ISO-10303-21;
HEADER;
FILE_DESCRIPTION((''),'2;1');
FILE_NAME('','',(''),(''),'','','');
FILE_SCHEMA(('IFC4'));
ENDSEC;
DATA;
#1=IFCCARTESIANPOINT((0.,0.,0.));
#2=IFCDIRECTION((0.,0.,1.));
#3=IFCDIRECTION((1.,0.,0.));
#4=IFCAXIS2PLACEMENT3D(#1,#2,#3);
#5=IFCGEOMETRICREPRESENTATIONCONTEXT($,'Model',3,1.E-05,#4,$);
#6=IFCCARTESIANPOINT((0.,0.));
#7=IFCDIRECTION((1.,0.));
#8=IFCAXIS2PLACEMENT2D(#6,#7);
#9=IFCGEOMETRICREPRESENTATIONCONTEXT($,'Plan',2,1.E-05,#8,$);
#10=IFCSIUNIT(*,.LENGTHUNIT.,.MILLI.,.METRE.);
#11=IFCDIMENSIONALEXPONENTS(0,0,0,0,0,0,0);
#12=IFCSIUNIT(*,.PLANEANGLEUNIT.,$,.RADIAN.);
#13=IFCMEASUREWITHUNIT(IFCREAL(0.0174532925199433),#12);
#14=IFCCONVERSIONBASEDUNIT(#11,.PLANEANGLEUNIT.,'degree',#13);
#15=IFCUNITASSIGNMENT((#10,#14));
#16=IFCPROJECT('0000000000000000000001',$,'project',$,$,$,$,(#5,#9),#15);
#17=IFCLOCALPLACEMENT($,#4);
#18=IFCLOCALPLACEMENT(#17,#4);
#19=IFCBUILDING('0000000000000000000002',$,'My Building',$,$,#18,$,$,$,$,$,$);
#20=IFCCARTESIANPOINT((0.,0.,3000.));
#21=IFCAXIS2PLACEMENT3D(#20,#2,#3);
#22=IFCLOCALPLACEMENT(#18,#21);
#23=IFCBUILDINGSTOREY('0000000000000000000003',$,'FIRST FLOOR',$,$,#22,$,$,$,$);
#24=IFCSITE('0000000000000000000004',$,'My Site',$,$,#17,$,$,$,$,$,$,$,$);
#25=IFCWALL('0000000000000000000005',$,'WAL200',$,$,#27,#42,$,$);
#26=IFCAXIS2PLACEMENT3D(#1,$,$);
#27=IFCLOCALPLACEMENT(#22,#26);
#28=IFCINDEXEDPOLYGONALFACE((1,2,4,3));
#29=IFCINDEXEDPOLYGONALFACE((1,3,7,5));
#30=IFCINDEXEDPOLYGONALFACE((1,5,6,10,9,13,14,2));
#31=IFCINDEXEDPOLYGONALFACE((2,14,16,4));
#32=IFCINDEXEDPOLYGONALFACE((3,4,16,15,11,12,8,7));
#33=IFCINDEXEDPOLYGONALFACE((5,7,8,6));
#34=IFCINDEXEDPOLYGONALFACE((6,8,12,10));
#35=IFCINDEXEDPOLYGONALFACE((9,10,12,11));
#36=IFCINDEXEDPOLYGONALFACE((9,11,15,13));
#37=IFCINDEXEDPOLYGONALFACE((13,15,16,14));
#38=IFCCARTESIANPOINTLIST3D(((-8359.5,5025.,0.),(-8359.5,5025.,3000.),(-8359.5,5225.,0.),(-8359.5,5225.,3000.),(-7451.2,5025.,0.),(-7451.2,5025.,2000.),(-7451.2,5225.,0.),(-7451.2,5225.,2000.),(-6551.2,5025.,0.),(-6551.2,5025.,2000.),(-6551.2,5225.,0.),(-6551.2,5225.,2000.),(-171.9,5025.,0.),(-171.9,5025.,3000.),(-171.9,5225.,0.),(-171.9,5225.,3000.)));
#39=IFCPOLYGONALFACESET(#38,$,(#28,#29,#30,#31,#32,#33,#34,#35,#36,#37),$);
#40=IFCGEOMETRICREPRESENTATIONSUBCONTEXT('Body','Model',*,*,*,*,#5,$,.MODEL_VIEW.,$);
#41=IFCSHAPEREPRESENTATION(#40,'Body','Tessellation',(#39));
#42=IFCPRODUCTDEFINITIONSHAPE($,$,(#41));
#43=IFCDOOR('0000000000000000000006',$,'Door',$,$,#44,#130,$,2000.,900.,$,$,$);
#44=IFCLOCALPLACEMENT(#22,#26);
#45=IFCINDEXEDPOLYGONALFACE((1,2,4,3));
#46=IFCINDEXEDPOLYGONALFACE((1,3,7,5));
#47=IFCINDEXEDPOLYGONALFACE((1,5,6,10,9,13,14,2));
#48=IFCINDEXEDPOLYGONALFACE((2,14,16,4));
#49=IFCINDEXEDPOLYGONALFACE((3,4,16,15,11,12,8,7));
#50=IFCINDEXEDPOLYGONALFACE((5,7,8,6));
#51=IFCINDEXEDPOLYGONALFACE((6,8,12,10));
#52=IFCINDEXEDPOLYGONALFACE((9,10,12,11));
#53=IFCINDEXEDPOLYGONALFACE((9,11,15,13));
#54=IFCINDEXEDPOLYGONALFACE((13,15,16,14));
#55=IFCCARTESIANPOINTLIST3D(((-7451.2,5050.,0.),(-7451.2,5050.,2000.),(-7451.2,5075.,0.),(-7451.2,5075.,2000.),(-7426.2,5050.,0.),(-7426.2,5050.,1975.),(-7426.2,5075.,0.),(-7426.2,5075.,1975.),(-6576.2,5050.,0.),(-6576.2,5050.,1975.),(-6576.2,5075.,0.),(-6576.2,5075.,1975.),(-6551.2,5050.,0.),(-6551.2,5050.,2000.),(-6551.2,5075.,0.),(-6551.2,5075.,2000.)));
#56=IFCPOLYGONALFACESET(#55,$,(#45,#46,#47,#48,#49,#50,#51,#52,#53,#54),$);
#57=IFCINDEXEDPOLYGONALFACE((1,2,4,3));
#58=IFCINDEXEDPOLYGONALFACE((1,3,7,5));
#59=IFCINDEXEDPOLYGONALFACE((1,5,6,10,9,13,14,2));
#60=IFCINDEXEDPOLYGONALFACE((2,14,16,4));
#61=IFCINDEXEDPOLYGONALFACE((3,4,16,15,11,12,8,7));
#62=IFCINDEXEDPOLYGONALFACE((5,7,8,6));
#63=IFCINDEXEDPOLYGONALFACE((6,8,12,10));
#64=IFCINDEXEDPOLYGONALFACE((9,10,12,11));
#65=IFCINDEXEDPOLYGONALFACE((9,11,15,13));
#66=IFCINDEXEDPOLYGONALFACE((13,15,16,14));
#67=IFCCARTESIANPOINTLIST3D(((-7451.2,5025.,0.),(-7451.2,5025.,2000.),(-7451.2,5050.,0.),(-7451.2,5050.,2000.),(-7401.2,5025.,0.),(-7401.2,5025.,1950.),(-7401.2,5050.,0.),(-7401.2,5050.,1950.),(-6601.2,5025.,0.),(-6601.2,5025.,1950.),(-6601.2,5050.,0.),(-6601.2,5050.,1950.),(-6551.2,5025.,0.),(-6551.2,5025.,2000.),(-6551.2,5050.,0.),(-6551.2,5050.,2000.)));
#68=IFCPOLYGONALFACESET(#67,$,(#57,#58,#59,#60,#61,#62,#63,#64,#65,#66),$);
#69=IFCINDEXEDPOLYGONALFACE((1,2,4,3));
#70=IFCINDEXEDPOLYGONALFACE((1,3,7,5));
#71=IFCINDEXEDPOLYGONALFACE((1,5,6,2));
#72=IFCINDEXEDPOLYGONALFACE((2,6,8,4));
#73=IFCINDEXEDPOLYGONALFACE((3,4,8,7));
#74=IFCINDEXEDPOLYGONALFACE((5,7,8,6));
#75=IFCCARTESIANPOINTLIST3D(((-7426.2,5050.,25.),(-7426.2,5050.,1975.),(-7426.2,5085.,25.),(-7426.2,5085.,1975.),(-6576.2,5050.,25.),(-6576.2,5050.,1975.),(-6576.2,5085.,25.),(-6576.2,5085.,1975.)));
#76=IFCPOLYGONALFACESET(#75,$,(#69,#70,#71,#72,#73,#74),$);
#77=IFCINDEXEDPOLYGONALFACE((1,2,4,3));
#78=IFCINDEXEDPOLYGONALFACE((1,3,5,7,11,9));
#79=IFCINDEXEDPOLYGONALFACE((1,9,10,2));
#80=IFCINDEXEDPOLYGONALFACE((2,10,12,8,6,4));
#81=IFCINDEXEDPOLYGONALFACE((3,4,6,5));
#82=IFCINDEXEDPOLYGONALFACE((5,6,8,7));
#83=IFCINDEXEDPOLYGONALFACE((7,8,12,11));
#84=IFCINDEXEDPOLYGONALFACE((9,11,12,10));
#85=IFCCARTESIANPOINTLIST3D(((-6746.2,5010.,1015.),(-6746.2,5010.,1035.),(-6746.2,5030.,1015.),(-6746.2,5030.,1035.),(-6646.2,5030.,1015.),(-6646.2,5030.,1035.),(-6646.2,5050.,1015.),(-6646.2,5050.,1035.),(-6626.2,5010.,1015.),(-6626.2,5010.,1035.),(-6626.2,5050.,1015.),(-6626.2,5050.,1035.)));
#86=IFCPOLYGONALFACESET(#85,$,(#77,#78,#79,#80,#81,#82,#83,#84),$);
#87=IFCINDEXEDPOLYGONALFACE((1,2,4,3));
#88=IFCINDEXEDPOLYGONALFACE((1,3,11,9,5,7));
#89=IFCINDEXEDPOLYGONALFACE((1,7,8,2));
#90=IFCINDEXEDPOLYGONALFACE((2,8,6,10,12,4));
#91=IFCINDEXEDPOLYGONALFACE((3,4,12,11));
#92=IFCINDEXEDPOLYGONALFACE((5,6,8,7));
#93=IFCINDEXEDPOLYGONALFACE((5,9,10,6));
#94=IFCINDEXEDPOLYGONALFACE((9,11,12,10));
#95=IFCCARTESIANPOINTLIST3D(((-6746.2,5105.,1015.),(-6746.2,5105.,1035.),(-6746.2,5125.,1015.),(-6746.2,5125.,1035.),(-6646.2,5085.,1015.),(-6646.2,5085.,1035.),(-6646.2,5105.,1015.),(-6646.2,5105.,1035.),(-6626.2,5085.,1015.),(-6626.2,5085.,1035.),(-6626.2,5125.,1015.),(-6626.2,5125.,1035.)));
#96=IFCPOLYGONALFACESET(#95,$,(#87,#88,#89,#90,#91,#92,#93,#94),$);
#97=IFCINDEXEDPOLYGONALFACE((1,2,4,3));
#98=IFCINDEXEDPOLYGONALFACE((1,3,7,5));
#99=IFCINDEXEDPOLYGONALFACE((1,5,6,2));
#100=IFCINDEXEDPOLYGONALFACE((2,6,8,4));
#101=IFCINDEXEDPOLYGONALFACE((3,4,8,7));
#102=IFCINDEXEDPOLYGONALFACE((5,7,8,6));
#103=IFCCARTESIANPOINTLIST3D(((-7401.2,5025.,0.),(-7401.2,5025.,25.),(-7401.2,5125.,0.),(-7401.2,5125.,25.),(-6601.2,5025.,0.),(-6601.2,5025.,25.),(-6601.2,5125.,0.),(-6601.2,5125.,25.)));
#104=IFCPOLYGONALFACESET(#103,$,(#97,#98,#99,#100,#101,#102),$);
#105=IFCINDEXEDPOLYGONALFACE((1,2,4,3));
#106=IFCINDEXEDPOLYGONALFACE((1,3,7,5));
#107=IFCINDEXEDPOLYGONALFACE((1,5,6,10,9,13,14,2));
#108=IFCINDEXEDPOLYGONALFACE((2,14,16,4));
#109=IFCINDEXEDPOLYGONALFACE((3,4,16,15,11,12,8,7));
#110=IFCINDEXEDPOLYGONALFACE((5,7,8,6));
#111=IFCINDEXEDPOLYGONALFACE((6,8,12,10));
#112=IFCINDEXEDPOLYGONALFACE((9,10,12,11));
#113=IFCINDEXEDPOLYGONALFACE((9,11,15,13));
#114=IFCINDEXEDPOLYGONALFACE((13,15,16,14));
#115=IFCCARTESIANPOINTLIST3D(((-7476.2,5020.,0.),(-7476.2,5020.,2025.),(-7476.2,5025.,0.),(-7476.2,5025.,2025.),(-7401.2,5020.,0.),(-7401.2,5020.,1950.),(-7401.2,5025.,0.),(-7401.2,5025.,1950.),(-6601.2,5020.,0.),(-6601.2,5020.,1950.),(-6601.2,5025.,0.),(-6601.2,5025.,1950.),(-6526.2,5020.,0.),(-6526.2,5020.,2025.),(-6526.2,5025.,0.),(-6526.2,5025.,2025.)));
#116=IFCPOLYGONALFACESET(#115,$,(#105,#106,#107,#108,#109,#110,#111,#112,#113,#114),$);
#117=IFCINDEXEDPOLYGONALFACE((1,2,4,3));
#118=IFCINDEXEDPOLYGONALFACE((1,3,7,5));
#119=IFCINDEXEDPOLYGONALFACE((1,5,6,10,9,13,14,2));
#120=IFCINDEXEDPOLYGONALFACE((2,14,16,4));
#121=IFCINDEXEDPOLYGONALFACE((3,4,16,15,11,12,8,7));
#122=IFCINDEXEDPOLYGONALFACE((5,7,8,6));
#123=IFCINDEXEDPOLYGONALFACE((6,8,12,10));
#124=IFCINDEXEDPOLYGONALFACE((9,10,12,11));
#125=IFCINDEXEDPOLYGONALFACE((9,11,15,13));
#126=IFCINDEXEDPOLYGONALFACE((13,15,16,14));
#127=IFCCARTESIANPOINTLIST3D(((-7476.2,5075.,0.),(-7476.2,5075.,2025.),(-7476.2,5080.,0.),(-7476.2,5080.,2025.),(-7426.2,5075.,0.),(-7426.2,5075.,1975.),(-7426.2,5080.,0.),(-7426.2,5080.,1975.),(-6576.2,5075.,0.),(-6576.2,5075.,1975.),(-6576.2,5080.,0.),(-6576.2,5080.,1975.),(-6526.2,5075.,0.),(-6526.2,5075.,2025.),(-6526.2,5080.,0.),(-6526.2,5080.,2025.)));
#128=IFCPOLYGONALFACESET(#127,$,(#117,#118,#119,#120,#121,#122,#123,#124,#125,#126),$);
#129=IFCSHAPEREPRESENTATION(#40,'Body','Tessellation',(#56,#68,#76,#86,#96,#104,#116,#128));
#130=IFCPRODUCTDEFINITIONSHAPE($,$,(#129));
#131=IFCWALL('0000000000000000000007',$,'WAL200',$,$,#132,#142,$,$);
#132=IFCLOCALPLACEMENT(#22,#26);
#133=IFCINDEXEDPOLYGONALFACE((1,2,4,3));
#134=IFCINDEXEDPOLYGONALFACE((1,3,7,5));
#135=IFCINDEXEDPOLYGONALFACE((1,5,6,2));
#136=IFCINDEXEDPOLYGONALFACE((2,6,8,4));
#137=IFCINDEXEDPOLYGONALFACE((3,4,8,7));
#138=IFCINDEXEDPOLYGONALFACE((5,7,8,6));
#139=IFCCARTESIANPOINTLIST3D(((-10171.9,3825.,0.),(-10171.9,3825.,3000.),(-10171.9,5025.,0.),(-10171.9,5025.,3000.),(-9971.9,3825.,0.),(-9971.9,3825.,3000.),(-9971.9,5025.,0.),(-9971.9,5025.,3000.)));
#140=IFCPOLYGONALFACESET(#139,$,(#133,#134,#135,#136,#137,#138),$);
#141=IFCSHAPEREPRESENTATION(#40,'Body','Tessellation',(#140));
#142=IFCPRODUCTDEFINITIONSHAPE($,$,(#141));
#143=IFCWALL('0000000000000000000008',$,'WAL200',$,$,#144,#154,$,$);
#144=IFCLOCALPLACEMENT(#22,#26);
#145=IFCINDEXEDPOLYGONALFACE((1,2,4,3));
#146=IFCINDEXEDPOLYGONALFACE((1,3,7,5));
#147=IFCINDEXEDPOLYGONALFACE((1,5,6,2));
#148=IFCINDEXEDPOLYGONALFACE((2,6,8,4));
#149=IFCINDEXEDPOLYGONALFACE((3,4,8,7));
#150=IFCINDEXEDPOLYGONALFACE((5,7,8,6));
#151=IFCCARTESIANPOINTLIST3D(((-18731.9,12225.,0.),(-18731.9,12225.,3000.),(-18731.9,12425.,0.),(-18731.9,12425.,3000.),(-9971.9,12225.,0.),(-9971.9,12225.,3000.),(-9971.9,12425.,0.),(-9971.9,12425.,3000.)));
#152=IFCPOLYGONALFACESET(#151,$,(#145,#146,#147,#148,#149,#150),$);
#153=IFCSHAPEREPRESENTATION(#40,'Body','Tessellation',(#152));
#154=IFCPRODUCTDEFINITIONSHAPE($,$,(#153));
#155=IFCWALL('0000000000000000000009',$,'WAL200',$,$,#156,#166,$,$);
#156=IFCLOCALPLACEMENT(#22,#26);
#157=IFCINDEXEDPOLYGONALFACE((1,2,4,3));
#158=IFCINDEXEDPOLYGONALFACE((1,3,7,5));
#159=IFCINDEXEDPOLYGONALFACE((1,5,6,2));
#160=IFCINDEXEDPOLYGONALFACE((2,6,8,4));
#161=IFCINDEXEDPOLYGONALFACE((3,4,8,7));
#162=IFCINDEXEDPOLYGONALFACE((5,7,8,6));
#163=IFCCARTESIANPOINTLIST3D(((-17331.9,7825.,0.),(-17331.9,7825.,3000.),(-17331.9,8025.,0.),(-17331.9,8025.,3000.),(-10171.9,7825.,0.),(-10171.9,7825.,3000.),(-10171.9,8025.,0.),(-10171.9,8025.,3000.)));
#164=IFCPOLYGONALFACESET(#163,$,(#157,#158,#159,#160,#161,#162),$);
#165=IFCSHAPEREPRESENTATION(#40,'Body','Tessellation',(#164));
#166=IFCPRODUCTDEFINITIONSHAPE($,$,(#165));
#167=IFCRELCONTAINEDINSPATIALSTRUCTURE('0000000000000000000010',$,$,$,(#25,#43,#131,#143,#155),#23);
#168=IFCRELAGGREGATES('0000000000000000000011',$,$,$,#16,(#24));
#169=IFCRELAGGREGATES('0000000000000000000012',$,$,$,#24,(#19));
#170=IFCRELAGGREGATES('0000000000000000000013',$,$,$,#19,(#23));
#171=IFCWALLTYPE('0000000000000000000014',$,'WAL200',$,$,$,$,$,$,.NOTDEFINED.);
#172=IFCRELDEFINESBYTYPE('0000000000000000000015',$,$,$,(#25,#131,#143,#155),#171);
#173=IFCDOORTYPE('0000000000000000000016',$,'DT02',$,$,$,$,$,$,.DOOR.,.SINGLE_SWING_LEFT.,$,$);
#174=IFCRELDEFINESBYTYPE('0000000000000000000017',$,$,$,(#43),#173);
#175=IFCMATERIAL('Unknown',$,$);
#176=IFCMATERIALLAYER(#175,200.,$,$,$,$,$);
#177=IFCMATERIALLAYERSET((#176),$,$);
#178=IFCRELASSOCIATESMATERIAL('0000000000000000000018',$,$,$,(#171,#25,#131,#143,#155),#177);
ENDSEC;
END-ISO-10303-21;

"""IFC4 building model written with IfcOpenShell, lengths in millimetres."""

from ifc_helpers import new_model, entity, si_unit, converted_unit, frame, origin_with_axes, origin_2d_with_axis, place, context, subcontext, project, spatial, line, indexed_curve, outline, extrude, shape, source, transform, mapped, material, layer, layer_set, layer_usage, type_object, type_shapes, element, fill, save


model = new_model("IFC4")

# Units and contexts
model_context = context("Model", 3, precision=1e-05, world=origin_with_axes())
plan_context = context("Plan", 2, precision=1e-05, world=origin_2d_with_axis())
body_context_1 = subcontext(model_context, "Body", "Model", "MODEL_VIEW")
body_context_2 = subcontext(plan_context, "Body", "Plan", "PLAN_VIEW")
ifc_project = project(units=[si_unit("LENGTHUNIT", "METRE", prefix="MILLI"), converted_unit("PLANEANGLEUNIT", "degree", entity("IfcReal", 0.0174532925199433), si_unit("PLANEANGLEUNIT", "RADIAN"), dimensions=[0, 0, 0, 0, 0, 0, 0])], contexts=[model_context, plan_context])

# Site, building, storey
site_placement = place(None, origin_with_axes())
site = spatial("IfcSite", under=ifc_project, at=site_placement, Name="My Site")
building_placement = place(site_placement, origin_with_axes())
building = spatial("IfcBuilding", under=site, at=building_placement, Name="My Building")
storey_placement = place(building_placement, frame((0.0, 0.0, 3000.0), z_axis=(0.0, 0.0, 1.0), x_axis=(1.0, 0.0, 0.0)))
storey = spatial("IfcBuildingStorey", under=building, at=storey_placement, Name="FIRST FLOOR")

# Shared definitions
ifc_material = material(Name="Unknown")

# Shared definitions
ifc_layer_1 = layer(ifc_material, 200.0)
ifc_layer_set_1 = layer_set([ifc_layer_1])
wall_type_1 = type_object("IfcWallType", Name="WAL200", PredefinedType="NOTDEFINED", material=ifc_layer_set_1)

# Wall, opening, door
shared_shape_1 = source(origin_with_axes(), body_context_1, "Body", "SweptSolid", [
    extrude(outline(indexed_curve([(0.0, 0.0), (900.0, 0.0), (900.0, 2000.0), (0.0, 2000.0)], segments=[line(1, 2), line(2, 3), line(3, 4), line(4, 1)])), frame((0.0, -100.0, 0.0), z_axis=(0.0, -1.0, 0.0), x_axis=(1.0, 0.0, 0.0)), (0.0, 0.0, -1.0), 300.0),
])
door_type = type_object("IfcDoorType", Name="DT02", OperationType="SINGLE_SWING_LEFT", PredefinedType="DOOR")
shared_shape_2 = source(origin_with_axes(), body_context_1, "Body", "SweptSolid", [
    extrude(outline(indexed_curve([(0.0, 0.0), (0.0, 2000.0), (900.0, 2000.0), (900.0, 0.0), (875.0, 0.0), (875.0, 1975.0), (25.0, 1975.0), (25.0, 0.0)], segments=[line(1, 2), line(2, 3), line(3, 4), line(4, 5), line(5, 6), line(6, 7), line(7, 8), line(8, 1)])), frame((0.0, 25.0, 0.0), z_axis=(0.0, -1.0, 0.0), x_axis=(1.0, 0.0, 0.0)), (0.0, 0.0, -1.0), 25.0),
    extrude(outline(indexed_curve([(0.0, 0.0), (0.0, 2000.0), (900.0, 2000.0), (900.0, 0.0), (850.0, 0.0), (850.0, 1950.0), (50.0, 1950.0), (50.0, 0.0)], segments=[line(1, 2), line(2, 3), line(3, 4), line(4, 5), line(5, 6), line(6, 7), line(7, 8), line(8, 1)])), frame((0.0, 0.0, 0.0), z_axis=(0.0, -1.0, 0.0), x_axis=(1.0, 0.0, 0.0)), (0.0, 0.0, -1.0), 25.0),
    extrude(outline(indexed_curve([(0.0, 0.0), (850.0, 0.0), (850.0, 35.0), (0.0, 35.0)], segments=[line(1, 2), line(2, 3), line(3, 4), line(4, 1)])), frame((25.0, 25.0, 25.0), z_axis=(0.0, 0.0, 1.0), x_axis=(1.0, 0.0, 0.0)), (0.0, 0.0, 1.0), 1950.0),
    extrude(outline(indexed_curve([(0.0, 0.0), (0.0, -40.0), (-120.0, -40.0), (-120.0, -20.0), (-20.0, -20.0), (-20.0, 0.0)], segments=[line(1, 2), line(2, 3), line(3, 4), line(4, 5), line(5, 6), line(6, 1)])), frame((825.0, 25.0, 1015.0), z_axis=(0.0, 0.0, 1.0), x_axis=(1.0, 0.0, 0.0)), (0.0, 0.0, 1.0), 20.0),
    extrude(outline(indexed_curve([(0.0, 0.0), (0.0, 40.0), (-120.0, 40.0), (-120.0, 20.0), (-20.0, 20.0), (-20.0, 0.0)], segments=[line(1, 2), line(2, 3), line(3, 4), line(4, 5), line(5, 6), line(6, 1)])), frame((825.0, 60.0, 1015.0), z_axis=(0.0, 0.0, 1.0), x_axis=(1.0, 0.0, 0.0)), (0.0, 0.0, 1.0), 20.0),
    extrude(outline(indexed_curve([(0.0, 0.0), (800.0, 0.0), (800.0, 100.0), (0.0, 100.0)], segments=[line(1, 2), line(2, 3), line(3, 4), line(4, 1)])), frame((50.0, 0.0, 0.0), z_axis=(0.0, 0.0, 1.0), x_axis=(1.0, 0.0, 0.0)), (0.0, 0.0, 1.0), 25.0),
    extrude(outline(indexed_curve([(0.0, 0.0), (0.0, 2025.0), (950.0, 2025.0), (950.0, 0.0), (875.0, 0.0), (875.0, 1950.0), (75.0, 1950.0), (75.0, 0.0)], segments=[line(1, 2), line(2, 3), line(3, 4), line(4, 5), line(5, 6), line(6, 7), line(7, 8), line(8, 1)])), frame((-25.0, -5.0, 0.0), z_axis=(0.0, -1.0, 0.0), x_axis=(1.0, 0.0, 0.0)), (0.0, 0.0, -1.0), 5.0),
    extrude(outline(indexed_curve([(0.0, 0.0), (0.0, 2025.0), (950.0, 2025.0), (950.0, 0.0), (900.0, 0.0), (900.0, 1975.0), (50.0, 1975.0), (50.0, 0.0)], segments=[line(1, 2), line(2, 3), line(3, 4), line(4, 5), line(5, 6), line(6, 7), line(7, 8), line(8, 1)])), frame((-25.0, 50.0, 0.0), z_axis=(0.0, -1.0, 0.0), x_axis=(1.0, 0.0, 0.0)), (0.0, 0.0, -1.0), 5.0),
])
shared_shape_3 = source(origin_with_axes(), body_context_2, "Body", "Curve2D", [
    entity("IfcIndexedPolyCurve", entity("IfcCartesianPointList2D", [[0.0, 0.0], [0.0, 50.0], [25.0, 50.0], [25.0, 25.0], [50.0, 25.0], [50.0, 0.0]]), [entity("IfcLineIndex", [1, 2]), entity("IfcLineIndex", [2, 3]), entity("IfcLineIndex", [3, 4]), entity("IfcLineIndex", [4, 5]), entity("IfcLineIndex", [5, 6]), entity("IfcLineIndex", [6, 1])]),
    entity("IfcIndexedPolyCurve", entity("IfcCartesianPointList2D", [[900.0, 0.0], [900.0, 50.0], [875.0, 50.0], [875.0, 25.0], [850.0, 25.0], [850.0, 0.0]]), [entity("IfcLineIndex", [1, 2]), entity("IfcLineIndex", [2, 3]), entity("IfcLineIndex", [3, 4]), entity("IfcLineIndex", [4, 5]), entity("IfcLineIndex", [5, 6]), entity("IfcLineIndex", [6, 1])]),
    entity("IfcTrimmedCurve", entity("IfcEllipse", entity("IfcAxis2Placement2D", entity("IfcCartesianPoint", [60.0, 50.0]), entity("IfcDirection", [1.0, 0.0])), 815.0, 850.0), [entity("IfcCartesianPoint", [875.0, 50.0])], [entity("IfcCartesianPoint", [60.0, 900.0])], True, "CARTESIAN"),
    entity("IfcIndexedPolyCurve", entity("IfcCartesianPointList2D", [[25.0, 50.0], [60.0, 50.0], [60.0, 900.0], [25.0, 900.0]]), [entity("IfcLineIndex", [1, 2]), entity("IfcLineIndex", [2, 3]), entity("IfcLineIndex", [3, 4]), entity("IfcLineIndex", [4, 1])]),
])
type_shapes(door_type, [shared_shape_2, shared_shape_3])
ifc_layer_usage_1 = layer_usage(ifc_layer_set_1, "AXIS2", "POSITIVE", 0.0)
wall_1_placement = place(storey_placement, frame((-8359.5, 5025.0, 0.0), z_axis=(0.0, 0.0, 1.0), x_axis=(1.0, 0.0, 0.0)))
wall_1 = element("IfcWall", 1, at=wall_1_placement, inside=storey, type_object=wall_type_1, material=ifc_layer_usage_1, Name="WAL200", context=body_context_1, shape_type="SweptSolid", body=[
    extrude(outline(indexed_curve([(0.0, 0.0), (0.0, 200.0), (8187.6, 200.0), (8187.6, 0.0), (0.0, 0.0)], self_intersect=False)), origin_with_axes(), (0.0, 0.0, 1.0), 3000.0),
])
opening_1_placement = place(wall_1_placement, frame((908.3, 0.0, 0.0), z_axis=(0.0, 0.0, 1.0), x_axis=(1.0, 0.0, 0.0)))
opening_1 = element("IfcOpeningElement", 2, at=opening_1_placement, cuts=wall_1, PredefinedType="OPENING", context=body_context_1, shape_type="MappedRepresentation", body=[
    mapped(shared_shape_1, transform((0.0, 0.0, 0.0), x_axis=(1.0, 0.0, 0.0), y_axis=(0.0, 1.0, 0.0), z_axis=(0.0, 0.0, 1.0), scale=1.0)),
])
door_1_placement = place(opening_1_placement, origin_with_axes())
door_1 = element("IfcDoor", 3, at=door_1_placement, inside=storey, type_object=door_type, Name="Door", OverallHeight=2000.0, OverallWidth=900.0, shapes=[
    shape(body_context_1, "Body", "MappedRepresentation", [mapped(shared_shape_2, transform((0.0, 0.0, 0.0), x_axis=(1.0, 0.0, 0.0), y_axis=(0.0, 1.0, 0.0), z_axis=(0.0, 0.0, 1.0), scale=1.0))]),
    shape(body_context_2, "Body", "MappedRepresentation", [mapped(shared_shape_3, transform((0.0, 0.0, 0.0), x_axis=(1.0, 0.0, 0.0), y_axis=(0.0, 1.0, 0.0), z_axis=(0.0, 0.0, 1.0), scale=1.0))]),
])
fill(opening_1, door_1)

# Walls
ifc_layer_usage_2 = layer_usage(ifc_layer_set_1, "AXIS2", "POSITIVE", 0.0)
wall_2_placement = place(storey_placement, frame((-10171.9, 5025.0, 0.0), z_axis=(0.0, 0.0, 1.0), x_axis=(-0.000001, -1.0, 0.0)))
element("IfcWall", 4, at=wall_2_placement, inside=storey, type_object=wall_type_1, material=ifc_layer_usage_2, Name="WAL200", context=body_context_1, shape_type="SweptSolid", body=[
    extrude(outline(indexed_curve([(0.0, 0.0), (0.0, 200.0), (1200.0, 200.0), (1200.0, 0.0), (0.0, 0.0)], self_intersect=False)), origin_with_axes(), (0.0, 0.0, 1.0), 3000.0),
])
ifc_layer_usage_3 = layer_usage(ifc_layer_set_1, "AXIS2", "POSITIVE", 0.0)
wall_3_placement = place(storey_placement, frame((-9971.9, 12425.0, 0.0), z_axis=(0.0, 0.0, 1.0), x_axis=(-1.0, 0.0, 0.0)))
element("IfcWall", 5, at=wall_3_placement, inside=storey, type_object=wall_type_1, material=ifc_layer_usage_3, Name="WAL200", context=body_context_1, shape_type="SweptSolid", body=[
    extrude(outline(indexed_curve([(0.0, 0.0), (0.0, 200.0), (8760.0, 200.0), (8760.0, 0.0), (0.0, 0.0)], self_intersect=False)), origin_with_axes(), (0.0, 0.0, 1.0), 3000.0),
])
ifc_layer_usage_4 = layer_usage(ifc_layer_set_1, "AXIS2", "POSITIVE", 0.0)
wall_4_placement = place(storey_placement, frame((-10171.9, 8025.0, 0.0), z_axis=(0.0, 0.0, 1.0), x_axis=(-1.0, 0.0, 0.0)))
element("IfcWall", 6, at=wall_4_placement, inside=storey, type_object=wall_type_1, material=ifc_layer_usage_4, Name="WAL200", context=body_context_1, shape_type="SweptSolid", body=[
    extrude(outline(indexed_curve([(0.0, 0.0), (0.0, 200.0), (7160.0, 200.0), (7160.0, 0.0), (0.0, 0.0)], self_intersect=False)), origin_with_axes(), (0.0, 0.0, 1.0), 3000.0),
])

save(model, "model.ifc")
